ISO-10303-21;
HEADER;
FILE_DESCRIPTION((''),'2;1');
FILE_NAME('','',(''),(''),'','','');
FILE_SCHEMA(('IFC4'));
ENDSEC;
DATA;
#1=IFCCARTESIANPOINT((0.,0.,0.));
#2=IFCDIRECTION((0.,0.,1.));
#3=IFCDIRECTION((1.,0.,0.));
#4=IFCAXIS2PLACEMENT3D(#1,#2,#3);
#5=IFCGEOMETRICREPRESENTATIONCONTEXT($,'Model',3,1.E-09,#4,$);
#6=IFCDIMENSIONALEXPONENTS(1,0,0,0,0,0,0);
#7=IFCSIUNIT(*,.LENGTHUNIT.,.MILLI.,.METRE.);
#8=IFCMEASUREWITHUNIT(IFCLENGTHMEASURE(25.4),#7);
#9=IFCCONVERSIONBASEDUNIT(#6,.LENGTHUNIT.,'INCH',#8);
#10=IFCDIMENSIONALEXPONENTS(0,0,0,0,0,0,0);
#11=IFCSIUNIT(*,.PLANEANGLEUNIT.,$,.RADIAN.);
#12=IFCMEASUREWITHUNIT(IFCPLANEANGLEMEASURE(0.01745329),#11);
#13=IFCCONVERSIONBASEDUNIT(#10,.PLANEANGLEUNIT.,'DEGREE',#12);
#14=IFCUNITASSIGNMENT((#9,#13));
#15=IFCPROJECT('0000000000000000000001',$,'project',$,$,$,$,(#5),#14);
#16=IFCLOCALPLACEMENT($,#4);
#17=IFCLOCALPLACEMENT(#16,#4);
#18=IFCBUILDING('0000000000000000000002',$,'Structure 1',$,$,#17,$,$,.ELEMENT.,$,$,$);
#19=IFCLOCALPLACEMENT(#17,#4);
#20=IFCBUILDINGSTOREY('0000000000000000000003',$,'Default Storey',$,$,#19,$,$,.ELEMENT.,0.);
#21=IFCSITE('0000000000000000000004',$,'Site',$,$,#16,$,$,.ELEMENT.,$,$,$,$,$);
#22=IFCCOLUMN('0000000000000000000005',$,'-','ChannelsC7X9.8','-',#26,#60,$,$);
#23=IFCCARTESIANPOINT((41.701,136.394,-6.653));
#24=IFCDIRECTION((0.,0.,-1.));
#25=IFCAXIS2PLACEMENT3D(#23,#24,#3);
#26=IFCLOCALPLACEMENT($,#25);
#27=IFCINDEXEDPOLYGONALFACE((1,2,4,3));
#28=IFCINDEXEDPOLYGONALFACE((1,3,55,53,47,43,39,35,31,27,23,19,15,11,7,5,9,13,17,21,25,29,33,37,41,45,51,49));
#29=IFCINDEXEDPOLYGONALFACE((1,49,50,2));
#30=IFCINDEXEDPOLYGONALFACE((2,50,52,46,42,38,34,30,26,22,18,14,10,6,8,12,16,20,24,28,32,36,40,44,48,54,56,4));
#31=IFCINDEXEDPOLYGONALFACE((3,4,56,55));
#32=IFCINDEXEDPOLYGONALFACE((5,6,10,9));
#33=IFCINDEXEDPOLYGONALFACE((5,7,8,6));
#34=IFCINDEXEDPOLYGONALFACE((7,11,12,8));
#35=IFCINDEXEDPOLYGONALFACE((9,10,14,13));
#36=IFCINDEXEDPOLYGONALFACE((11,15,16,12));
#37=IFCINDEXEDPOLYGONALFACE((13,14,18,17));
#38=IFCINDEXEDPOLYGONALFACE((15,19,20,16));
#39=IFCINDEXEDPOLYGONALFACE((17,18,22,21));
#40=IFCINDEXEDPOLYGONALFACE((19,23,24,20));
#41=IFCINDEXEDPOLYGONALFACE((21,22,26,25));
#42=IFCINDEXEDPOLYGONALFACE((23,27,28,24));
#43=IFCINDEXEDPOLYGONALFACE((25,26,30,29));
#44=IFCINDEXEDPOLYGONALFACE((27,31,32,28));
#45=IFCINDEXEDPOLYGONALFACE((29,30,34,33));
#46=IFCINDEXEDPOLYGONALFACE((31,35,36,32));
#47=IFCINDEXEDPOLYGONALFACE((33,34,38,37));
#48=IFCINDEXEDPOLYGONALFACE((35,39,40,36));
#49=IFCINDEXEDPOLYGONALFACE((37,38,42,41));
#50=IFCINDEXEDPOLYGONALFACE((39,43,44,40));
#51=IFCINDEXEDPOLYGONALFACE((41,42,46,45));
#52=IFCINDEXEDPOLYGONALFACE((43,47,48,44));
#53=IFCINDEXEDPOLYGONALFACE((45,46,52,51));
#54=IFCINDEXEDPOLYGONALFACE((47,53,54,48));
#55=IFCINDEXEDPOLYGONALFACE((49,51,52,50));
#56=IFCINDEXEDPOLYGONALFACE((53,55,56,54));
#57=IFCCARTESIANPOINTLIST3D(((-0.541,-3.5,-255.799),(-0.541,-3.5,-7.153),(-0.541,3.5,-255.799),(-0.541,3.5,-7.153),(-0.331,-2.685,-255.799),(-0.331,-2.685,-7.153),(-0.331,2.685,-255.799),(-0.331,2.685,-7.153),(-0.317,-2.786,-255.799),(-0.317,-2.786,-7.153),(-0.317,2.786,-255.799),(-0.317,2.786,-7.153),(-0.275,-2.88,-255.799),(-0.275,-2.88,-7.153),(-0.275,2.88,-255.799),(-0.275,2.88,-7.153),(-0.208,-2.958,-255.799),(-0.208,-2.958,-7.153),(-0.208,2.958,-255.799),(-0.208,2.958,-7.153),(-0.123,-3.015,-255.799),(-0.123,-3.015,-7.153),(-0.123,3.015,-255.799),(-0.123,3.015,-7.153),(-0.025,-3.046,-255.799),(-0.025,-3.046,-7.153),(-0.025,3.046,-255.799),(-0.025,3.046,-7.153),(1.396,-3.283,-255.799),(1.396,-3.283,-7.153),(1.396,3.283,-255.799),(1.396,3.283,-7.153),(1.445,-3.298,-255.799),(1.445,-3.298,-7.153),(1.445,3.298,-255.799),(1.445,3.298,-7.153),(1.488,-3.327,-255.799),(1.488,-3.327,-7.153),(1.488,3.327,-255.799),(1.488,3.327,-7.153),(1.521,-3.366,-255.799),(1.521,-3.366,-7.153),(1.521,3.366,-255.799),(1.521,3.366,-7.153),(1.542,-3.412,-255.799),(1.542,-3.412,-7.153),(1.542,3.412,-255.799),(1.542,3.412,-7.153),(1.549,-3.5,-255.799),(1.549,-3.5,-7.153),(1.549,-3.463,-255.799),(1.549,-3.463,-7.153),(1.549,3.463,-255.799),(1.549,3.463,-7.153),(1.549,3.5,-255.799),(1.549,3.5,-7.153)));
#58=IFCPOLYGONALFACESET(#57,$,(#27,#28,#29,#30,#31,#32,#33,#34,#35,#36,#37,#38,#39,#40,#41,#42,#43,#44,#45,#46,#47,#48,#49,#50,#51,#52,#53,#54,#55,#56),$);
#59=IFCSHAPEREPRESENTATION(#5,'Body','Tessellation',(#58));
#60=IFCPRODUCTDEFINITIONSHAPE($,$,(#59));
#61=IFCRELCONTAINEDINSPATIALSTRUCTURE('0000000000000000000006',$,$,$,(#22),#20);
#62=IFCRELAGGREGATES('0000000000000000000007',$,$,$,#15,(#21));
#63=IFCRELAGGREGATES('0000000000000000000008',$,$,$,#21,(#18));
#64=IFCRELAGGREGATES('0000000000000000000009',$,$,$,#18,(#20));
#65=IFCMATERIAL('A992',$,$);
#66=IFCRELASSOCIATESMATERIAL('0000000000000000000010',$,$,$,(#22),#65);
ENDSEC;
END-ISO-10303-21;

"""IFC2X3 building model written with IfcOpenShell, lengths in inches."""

from ifc_helpers import new_model, entity, si_unit, converted_unit, frame, frame_2d, origin, origin_with_axes, place, context, project, spatial, u_section, extrude, clip, halfspace, material, element, save


model = new_model("IFC2X3")

# Units and contexts
model_context = context("Model", 3, precision=1e-09, world=origin_with_axes())
ifc_project = project(units=[converted_unit("LENGTHUNIT", "INCH", entity("IfcLengthMeasure", 25.4), si_unit("LENGTHUNIT", "METRE", prefix="MILLI"), dimensions=[1, 0, 0, 0, 0, 0, 0]), converted_unit("PLANEANGLEUNIT", "DEGREE", entity("IfcPlaneAngleMeasure", 0.01745329), si_unit("PLANEANGLEUNIT", "RADIAN"), dimensions=[0, 0, 0, 0, 0, 0, 0])], contexts=[model_context])

# Site, building, storey
site_placement = place(None, origin_with_axes())
site = spatial("IfcSite", under=ifc_project, at=site_placement, Name="Site", CompositionType="ELEMENT")
building_placement = place(site_placement, origin_with_axes())
building = spatial("IfcBuilding", under=site, at=building_placement, Name="Structure 1", CompositionType="ELEMENT")
storey_placement = place(building_placement, origin_with_axes())
storey = spatial("IfcBuildingStorey", under=building, at=storey_placement, Name="Default Storey", CompositionType="ELEMENT", Elevation=0.0)

# Column
ifc_material_1 = material(Name="A992")
column_1_placement = place(None, frame((41.701, 136.394, -6.653), z_axis=(0.0, 0.0, -1.0), x_axis=(1.0, 0.0, 0.0)))
element("IfcColumn", 1, at=column_1_placement, inside=storey, material=ifc_material_1, Name="-", Description="ChannelsC7X9.8", ObjectType="-", context=model_context, shape_type="Clipping", body=[
    clip(extrude(u_section(Depth=7.0, FlangeWidth=2.09, WebThickness=0.21, FlangeThickness=0.366, FilletRadius=0.366, EdgeRadius=0.183, FlangeSlope=9.462, at=frame_2d((0.504, 0.0))), origin(), (0.0, 0.0, -1.0), 255.799), halfspace(frame((-41.701, 136.394, -7.153), z_axis=(0.0, 0.0, -1.0), x_axis=(1.0, 0.0, 0.0)), True)),
])

save(model, "model.ifc")
